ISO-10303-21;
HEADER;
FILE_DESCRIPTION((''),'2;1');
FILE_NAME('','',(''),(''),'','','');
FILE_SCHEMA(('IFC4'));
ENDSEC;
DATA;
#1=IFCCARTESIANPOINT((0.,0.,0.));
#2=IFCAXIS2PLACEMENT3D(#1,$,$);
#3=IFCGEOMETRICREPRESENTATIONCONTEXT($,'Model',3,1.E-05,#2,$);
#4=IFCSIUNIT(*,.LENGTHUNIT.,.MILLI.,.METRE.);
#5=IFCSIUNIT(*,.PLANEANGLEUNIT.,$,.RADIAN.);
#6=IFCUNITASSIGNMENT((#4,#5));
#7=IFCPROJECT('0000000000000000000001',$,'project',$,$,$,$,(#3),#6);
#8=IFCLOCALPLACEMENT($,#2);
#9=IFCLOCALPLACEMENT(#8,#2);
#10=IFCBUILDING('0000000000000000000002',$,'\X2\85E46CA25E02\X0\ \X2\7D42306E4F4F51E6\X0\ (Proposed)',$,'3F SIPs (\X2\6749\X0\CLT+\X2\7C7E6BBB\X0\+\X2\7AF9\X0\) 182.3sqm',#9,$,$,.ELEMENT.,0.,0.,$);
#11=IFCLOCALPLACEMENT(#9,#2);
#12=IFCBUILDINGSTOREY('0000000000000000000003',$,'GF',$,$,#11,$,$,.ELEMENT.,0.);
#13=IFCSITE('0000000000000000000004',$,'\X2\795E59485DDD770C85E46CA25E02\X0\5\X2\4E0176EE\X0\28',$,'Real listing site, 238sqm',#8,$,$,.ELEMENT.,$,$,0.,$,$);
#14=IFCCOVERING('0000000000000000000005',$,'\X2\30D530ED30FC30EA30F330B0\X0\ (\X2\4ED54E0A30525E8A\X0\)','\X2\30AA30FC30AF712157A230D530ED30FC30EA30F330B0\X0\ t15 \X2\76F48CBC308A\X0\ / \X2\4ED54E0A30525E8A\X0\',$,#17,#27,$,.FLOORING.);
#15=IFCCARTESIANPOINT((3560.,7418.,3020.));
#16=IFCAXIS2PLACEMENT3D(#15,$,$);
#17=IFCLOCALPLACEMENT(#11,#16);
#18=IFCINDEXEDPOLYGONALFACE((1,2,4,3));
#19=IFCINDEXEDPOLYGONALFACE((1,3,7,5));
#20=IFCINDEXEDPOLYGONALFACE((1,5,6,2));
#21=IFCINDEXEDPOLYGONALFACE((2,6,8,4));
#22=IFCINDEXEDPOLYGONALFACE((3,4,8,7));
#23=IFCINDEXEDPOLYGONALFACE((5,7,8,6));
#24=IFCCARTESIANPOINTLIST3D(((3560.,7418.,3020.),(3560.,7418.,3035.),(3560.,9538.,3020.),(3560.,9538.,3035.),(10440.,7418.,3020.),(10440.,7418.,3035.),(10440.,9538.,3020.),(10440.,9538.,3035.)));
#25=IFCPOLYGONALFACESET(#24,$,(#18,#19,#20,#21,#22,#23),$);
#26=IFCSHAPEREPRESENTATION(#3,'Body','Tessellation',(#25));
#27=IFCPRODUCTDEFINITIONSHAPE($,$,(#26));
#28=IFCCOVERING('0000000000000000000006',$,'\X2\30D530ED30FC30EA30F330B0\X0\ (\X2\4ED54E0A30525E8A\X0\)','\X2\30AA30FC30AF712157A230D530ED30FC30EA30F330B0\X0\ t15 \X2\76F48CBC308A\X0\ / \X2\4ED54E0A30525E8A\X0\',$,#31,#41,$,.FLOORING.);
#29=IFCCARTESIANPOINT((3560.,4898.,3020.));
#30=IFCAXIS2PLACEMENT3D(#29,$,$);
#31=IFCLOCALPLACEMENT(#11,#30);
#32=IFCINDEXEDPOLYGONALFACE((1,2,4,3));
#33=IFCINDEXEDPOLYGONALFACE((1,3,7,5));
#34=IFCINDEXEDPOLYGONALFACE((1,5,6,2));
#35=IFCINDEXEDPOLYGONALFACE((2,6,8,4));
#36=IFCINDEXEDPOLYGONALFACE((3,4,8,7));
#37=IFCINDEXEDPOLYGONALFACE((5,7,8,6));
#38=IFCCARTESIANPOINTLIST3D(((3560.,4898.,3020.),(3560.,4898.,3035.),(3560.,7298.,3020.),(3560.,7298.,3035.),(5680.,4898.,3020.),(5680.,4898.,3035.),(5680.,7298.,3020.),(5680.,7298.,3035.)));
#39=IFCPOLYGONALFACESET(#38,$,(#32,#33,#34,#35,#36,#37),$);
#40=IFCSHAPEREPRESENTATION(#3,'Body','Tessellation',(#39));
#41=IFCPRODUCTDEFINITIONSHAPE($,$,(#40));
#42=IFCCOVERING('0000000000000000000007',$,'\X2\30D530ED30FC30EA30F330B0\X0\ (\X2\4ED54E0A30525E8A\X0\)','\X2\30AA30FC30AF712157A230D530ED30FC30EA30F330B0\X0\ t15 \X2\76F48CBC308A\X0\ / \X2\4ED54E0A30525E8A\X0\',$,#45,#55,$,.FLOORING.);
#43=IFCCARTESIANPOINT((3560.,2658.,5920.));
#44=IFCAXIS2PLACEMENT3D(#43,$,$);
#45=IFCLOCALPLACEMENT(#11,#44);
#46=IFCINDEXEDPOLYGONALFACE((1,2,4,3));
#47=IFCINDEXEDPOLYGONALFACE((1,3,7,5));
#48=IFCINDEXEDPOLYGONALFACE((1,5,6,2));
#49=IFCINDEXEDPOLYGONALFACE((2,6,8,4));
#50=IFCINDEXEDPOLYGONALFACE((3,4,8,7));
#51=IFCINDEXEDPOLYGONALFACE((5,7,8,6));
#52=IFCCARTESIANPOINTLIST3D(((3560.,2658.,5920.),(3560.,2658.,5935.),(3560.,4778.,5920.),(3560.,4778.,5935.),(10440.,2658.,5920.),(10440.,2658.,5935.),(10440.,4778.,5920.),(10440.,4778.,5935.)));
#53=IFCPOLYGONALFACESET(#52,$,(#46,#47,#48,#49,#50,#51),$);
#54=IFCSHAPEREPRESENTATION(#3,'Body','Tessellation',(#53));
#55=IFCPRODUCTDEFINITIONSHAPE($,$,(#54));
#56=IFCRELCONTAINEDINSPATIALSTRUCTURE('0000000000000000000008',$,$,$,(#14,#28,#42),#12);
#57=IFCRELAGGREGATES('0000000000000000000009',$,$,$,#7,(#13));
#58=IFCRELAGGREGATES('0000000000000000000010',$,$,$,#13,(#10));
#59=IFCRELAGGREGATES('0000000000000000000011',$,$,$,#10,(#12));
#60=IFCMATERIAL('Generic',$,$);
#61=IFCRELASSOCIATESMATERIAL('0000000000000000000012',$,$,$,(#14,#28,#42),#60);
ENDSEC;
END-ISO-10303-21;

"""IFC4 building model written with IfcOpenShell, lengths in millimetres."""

from ifc_helpers import new_model, si_unit, frame, frame_2d, origin, place, context, project, spatial, rectangle, extrude, material, element, save


model = new_model("IFC4")

# Units and contexts
model_context = context("Model", 3, precision=1e-05, world=origin())
ifc_project = project(units=[si_unit("LENGTHUNIT", "METRE", prefix="MILLI"), si_unit("PLANEANGLEUNIT", "RADIAN")], contexts=[model_context])

# Site, building, storey
site_placement = place(None, origin())
site = spatial("IfcSite", under=ifc_project, at=site_placement, Name="神奈川県藤沢市5丁目28", ObjectType="Real listing site, 238sqm", CompositionType="ELEMENT", RefElevation=0.0)
building_placement = place(site_placement, origin())
building = spatial("IfcBuilding", under=site, at=building_placement, Name="藤沢市 終の住処 (Proposed)", ObjectType="3F SIPs (杉CLT+籾殻+竹) 182.3sqm", CompositionType="ELEMENT", ElevationOfRefHeight=0.0, ElevationOfTerrain=0.0)
storey_placement = place(building_placement, origin())
storey = spatial("IfcBuildingStorey", under=building, at=storey_placement, Name="GF", CompositionType="ELEMENT", Elevation=0.0)

# Shared definitions
ifc_material_1 = material(Name="Generic")

# Coverings
covering_1_placement = place(storey_placement, frame((3560.0, 7418.0, 3020.0)))
element("IfcCovering", 1, at=covering_1_placement, inside=storey, material=ifc_material_1, Name="フローリング (仕上げ床)", Description="オーク無垢フローリング t15 直貼り / 仕上げ床", PredefinedType="FLOORING", context=model_context, shape_type="SweptSolid", body=[
    extrude(rectangle(XDim=6880.0, YDim=2120.0, at=frame_2d((3440.0, 1060.0))), frame((3560.0, 7418.0, 3020.0)), (0.0, 0.0, 1.0), 15.0),
])
covering_2_placement = place(storey_placement, frame((3560.0, 4898.0, 3020.0)))
element("IfcCovering", 2, at=covering_2_placement, inside=storey, material=ifc_material_1, Name="フローリング (仕上げ床)", Description="オーク無垢フローリング t15 直貼り / 仕上げ床", PredefinedType="FLOORING", context=model_context, shape_type="SweptSolid", body=[
    extrude(rectangle(XDim=2120.0, YDim=2400.0, at=frame_2d((1060.0, 1200.0))), frame((3560.0, 4898.0, 3020.0)), (0.0, 0.0, 1.0), 15.0),
])
covering_3_placement = place(storey_placement, frame((3560.0, 2658.0, 5920.0)))
element("IfcCovering", 3, at=covering_3_placement, inside=storey, material=ifc_material_1, Name="フローリング (仕上げ床)", Description="オーク無垢フローリング t15 直貼り / 仕上げ床", PredefinedType="FLOORING", context=model_context, shape_type="SweptSolid", body=[
    extrude(rectangle(XDim=6880.0, YDim=2120.0, at=frame_2d((3440.0, 1060.0))), frame((3560.0, 2658.0, 5920.0)), (0.0, 0.0, 1.0), 15.0),
])

save(model, "model.ifc")
